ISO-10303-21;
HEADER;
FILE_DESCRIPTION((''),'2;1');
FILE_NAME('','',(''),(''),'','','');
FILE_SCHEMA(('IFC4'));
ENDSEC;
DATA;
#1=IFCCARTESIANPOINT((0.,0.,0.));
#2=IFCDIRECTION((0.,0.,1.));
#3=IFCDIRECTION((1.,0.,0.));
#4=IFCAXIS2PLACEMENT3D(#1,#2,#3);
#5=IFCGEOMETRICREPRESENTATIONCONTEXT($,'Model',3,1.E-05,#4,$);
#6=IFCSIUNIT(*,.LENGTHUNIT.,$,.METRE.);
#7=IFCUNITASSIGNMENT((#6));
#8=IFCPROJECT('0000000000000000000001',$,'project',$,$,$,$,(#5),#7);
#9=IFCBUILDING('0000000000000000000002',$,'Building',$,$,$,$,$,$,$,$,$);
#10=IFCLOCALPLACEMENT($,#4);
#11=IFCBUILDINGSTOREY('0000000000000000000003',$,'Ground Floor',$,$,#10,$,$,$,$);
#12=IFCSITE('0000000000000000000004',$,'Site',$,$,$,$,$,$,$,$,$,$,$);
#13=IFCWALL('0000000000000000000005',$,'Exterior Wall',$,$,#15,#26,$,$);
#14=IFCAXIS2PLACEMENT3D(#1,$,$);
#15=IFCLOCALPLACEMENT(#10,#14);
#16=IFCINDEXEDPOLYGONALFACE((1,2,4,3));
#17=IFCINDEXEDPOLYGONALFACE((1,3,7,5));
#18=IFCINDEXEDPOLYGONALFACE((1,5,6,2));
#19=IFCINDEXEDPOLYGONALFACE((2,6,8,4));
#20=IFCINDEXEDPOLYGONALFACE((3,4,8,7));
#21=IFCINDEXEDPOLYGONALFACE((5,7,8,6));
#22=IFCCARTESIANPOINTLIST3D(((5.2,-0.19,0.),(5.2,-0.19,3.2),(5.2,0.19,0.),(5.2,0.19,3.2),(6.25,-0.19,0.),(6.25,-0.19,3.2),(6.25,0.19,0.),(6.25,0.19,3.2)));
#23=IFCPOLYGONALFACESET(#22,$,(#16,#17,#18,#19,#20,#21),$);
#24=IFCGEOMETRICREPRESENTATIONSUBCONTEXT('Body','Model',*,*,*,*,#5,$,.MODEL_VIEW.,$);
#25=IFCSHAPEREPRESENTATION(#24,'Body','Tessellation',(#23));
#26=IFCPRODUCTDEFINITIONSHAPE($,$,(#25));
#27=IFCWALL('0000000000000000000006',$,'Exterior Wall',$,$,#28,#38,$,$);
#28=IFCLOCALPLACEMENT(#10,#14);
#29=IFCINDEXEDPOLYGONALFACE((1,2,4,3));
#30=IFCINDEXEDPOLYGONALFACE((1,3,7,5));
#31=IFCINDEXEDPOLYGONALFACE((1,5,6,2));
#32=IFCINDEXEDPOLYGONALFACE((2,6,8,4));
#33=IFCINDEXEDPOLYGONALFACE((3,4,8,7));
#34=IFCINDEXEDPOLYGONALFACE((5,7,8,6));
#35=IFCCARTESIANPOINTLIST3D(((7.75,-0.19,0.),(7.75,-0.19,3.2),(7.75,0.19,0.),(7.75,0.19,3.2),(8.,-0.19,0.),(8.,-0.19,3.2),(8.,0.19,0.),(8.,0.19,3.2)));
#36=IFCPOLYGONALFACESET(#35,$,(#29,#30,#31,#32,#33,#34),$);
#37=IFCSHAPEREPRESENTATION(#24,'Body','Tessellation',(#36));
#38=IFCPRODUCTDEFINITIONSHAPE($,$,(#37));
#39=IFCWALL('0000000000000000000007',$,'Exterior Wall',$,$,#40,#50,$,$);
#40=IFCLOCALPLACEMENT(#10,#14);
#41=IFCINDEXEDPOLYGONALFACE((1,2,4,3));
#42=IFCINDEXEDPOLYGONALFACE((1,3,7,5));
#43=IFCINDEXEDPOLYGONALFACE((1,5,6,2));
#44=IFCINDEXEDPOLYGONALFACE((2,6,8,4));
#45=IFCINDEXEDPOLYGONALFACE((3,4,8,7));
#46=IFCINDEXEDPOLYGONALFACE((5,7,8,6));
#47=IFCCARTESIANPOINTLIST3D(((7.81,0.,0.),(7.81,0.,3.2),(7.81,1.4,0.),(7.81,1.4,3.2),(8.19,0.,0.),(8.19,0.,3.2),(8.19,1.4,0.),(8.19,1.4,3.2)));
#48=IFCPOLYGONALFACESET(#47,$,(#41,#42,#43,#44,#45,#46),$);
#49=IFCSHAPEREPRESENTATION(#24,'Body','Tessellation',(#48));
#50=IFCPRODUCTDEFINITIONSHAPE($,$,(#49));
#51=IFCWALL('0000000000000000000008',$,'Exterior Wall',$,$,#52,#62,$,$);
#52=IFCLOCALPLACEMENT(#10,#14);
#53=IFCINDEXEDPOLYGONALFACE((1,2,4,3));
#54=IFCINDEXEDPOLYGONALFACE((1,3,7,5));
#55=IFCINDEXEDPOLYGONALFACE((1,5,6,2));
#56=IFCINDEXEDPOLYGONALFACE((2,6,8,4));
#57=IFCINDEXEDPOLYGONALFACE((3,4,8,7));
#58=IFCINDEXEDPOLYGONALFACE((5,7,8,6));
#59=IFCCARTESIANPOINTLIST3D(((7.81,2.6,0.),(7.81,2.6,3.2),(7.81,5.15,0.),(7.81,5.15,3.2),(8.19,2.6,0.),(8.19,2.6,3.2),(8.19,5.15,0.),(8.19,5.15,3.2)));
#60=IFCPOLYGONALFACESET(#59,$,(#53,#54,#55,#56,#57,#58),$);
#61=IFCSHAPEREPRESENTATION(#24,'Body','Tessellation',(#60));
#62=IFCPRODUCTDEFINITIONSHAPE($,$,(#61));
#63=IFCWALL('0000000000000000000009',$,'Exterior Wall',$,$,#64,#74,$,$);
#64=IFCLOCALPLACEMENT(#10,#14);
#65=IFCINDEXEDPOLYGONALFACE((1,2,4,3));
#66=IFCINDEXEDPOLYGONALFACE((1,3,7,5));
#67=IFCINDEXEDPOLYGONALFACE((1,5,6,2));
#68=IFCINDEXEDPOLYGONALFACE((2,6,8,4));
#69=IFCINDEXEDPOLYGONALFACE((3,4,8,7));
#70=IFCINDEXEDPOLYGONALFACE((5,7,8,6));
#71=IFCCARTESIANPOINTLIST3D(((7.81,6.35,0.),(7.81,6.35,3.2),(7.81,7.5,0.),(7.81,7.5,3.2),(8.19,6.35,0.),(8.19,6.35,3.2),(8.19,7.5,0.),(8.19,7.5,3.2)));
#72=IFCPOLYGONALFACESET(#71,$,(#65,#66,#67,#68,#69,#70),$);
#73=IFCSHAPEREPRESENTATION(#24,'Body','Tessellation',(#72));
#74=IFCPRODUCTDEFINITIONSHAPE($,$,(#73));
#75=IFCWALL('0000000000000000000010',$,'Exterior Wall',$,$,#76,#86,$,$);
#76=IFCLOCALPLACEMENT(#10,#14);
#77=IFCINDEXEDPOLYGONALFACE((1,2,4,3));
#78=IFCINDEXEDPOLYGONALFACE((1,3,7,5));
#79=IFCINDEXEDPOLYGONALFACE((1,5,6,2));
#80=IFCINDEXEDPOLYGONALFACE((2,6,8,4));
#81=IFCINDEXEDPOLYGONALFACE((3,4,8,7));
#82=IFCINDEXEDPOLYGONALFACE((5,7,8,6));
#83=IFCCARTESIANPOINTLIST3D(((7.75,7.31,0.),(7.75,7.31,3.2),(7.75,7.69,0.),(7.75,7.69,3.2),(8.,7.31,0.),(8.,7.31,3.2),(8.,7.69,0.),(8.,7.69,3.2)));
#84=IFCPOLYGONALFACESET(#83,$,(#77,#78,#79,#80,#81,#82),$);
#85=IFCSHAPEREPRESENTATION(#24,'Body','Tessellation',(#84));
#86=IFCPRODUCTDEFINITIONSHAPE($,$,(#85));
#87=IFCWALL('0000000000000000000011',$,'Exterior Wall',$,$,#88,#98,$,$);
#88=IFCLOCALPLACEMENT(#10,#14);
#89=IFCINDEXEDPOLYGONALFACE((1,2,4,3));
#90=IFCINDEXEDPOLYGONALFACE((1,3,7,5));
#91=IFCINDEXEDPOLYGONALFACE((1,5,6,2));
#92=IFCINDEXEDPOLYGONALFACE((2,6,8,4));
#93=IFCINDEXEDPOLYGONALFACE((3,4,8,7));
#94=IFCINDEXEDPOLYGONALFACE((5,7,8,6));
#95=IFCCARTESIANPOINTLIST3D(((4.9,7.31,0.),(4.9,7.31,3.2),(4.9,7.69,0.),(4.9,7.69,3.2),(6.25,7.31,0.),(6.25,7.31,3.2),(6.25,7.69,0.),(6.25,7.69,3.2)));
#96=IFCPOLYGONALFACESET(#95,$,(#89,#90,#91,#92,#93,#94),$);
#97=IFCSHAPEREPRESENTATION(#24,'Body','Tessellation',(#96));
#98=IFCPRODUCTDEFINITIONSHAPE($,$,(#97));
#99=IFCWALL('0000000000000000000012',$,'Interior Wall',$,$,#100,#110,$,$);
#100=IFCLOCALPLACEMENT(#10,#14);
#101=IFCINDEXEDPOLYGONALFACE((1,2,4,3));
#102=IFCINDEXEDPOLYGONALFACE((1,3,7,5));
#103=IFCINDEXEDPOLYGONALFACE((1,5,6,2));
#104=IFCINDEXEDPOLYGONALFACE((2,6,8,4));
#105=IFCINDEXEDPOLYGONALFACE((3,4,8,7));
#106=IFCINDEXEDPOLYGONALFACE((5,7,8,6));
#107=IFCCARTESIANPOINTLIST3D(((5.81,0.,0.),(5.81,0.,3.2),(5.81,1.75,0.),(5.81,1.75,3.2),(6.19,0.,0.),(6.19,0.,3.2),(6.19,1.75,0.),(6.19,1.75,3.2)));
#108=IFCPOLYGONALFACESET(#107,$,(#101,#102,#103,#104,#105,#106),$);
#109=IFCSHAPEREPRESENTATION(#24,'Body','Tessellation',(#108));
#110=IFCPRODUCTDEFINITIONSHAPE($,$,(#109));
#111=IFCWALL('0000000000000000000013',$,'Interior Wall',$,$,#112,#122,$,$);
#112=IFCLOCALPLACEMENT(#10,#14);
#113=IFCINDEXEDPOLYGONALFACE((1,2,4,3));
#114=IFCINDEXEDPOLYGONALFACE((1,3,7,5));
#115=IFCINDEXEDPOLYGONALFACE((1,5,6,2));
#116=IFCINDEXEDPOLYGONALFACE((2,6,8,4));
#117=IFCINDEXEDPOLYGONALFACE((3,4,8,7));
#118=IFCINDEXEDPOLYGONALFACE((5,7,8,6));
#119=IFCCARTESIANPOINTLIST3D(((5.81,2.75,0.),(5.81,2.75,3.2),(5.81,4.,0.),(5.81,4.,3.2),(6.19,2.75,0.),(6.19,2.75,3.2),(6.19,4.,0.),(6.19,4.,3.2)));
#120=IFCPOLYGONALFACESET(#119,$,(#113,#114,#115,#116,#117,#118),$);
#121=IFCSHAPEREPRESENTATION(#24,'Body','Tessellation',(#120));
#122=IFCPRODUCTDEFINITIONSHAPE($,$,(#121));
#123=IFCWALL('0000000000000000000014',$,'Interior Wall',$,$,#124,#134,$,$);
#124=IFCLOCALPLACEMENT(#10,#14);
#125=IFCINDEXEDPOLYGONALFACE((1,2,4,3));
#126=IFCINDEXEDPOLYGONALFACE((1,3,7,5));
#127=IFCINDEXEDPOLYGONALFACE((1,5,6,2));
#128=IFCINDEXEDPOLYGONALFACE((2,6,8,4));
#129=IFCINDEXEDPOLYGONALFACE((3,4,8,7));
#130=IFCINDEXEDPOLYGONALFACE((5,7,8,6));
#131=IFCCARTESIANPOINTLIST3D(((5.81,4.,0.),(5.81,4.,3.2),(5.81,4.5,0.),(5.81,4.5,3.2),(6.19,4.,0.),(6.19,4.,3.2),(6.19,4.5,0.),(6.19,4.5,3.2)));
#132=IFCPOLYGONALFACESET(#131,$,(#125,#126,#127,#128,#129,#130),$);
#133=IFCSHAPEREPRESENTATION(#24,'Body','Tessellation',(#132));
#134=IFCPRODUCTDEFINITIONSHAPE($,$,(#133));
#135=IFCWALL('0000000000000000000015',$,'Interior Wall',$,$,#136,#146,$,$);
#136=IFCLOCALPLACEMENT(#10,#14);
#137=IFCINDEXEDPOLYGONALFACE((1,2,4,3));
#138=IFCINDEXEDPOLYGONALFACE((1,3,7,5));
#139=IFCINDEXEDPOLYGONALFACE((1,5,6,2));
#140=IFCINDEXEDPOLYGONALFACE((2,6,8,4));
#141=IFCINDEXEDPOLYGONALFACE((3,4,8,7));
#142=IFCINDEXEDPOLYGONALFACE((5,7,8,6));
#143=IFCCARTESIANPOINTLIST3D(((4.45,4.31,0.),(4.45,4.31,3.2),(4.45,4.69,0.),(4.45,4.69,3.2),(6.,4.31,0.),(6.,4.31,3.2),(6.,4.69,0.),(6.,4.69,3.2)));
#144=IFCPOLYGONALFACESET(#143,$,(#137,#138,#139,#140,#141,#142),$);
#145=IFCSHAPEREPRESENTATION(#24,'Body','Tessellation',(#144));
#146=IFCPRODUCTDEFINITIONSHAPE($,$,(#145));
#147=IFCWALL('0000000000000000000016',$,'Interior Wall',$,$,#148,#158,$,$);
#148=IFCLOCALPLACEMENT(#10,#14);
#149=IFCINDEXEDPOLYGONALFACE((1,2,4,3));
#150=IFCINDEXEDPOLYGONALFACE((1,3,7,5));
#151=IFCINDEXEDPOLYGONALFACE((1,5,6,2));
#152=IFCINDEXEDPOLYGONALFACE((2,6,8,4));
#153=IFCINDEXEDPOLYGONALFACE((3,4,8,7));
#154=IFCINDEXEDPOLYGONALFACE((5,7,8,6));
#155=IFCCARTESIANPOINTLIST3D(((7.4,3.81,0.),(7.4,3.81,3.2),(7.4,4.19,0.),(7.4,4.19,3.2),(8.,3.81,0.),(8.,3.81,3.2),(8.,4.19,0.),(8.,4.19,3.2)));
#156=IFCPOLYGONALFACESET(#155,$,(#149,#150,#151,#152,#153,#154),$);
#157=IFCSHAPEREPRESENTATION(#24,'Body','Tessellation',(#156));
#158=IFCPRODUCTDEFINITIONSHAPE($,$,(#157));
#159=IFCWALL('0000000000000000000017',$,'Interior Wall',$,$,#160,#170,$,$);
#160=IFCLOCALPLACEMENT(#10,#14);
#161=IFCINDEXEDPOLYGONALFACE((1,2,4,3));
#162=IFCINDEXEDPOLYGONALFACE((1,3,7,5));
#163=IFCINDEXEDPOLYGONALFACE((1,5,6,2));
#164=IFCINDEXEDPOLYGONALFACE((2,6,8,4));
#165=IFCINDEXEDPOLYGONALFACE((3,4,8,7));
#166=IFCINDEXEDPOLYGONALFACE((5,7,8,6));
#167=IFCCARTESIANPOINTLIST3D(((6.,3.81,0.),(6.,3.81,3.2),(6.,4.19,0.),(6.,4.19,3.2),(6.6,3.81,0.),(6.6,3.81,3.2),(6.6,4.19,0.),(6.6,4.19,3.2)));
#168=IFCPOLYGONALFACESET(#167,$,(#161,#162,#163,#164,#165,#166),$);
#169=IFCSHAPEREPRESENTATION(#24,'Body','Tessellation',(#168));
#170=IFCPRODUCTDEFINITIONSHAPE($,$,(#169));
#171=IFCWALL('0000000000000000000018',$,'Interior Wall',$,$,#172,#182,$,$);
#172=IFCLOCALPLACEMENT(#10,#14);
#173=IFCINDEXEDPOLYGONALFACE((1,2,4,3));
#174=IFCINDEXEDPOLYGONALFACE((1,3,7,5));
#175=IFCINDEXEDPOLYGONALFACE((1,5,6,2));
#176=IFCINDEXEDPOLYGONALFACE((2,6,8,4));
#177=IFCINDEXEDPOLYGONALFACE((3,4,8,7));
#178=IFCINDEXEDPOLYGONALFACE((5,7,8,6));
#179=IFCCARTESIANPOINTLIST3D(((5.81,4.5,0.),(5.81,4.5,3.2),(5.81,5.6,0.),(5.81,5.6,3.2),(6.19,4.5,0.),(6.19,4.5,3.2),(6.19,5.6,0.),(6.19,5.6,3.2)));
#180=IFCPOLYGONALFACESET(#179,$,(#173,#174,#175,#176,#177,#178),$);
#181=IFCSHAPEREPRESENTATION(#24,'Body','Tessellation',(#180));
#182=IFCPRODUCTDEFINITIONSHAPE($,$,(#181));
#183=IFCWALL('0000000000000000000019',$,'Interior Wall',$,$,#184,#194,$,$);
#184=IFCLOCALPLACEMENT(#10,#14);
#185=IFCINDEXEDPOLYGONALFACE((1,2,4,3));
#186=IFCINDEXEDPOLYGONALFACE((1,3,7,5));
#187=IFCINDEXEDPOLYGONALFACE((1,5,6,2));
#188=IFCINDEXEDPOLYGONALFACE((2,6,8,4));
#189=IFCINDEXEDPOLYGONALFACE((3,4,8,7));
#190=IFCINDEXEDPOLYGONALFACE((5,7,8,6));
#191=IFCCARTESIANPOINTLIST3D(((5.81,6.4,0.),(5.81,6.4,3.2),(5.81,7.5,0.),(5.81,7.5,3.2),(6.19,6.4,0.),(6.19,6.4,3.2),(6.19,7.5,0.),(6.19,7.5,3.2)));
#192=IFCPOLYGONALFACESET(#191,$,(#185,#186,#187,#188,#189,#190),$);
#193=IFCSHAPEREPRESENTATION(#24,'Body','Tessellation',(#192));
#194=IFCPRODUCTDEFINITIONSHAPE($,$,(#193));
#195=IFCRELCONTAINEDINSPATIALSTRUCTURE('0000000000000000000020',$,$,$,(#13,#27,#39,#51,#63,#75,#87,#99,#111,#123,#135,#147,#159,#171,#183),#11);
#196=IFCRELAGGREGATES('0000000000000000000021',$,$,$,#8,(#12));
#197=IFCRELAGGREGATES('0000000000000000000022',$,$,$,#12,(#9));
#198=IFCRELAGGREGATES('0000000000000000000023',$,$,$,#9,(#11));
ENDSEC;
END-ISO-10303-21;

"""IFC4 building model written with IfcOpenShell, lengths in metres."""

from ifc_helpers import new_model, si_unit, frame, origin_with_axes, place, context, subcontext, project, spatial, indexed_curve, outline, extrude, element, save


model = new_model("IFC4")

# Units and contexts
model_context = context("Model", 3, precision=1e-05, world=origin_with_axes())
body_context = subcontext(model_context, "Body", "Model", "MODEL_VIEW")
ifc_project = project(units=[si_unit("LENGTHUNIT", "METRE")], contexts=[model_context])

# Site, building, storey
site = spatial("IfcSite", under=ifc_project, Name="Site")
building = spatial("IfcBuilding", under=site, Name="Building")
storey_placement = place(None, origin_with_axes())
storey = spatial("IfcBuildingStorey", under=building, at=storey_placement, Name="Ground Floor")

# Walls
wall_1_placement = place(storey_placement, frame((5.2, 0.0, 0.0), z_axis=(0.0, 0.0, 1.0), x_axis=(1.0, 0.0, 0.0)))
element("IfcWall", 1, at=wall_1_placement, inside=storey, Name="Exterior Wall", context=body_context, shape_type="SweptSolid", body=[
    extrude(outline(indexed_curve([(0.0, 0.0), (0.0, 0.38), (1.05, 0.38), (1.05, 0.0), (0.0, 0.0)], self_intersect=False)), frame((0.0, -0.19, 0.0), z_axis=(0.0, 0.0, 1.0), x_axis=(1.0, 0.0, 0.0)), (0.0, 0.0, 1.0), 3.2),
])
wall_2_placement = place(storey_placement, frame((7.75, 0.0, 0.0), z_axis=(0.0, 0.0, 1.0), x_axis=(1.0, 0.0, 0.0)))
element("IfcWall", 2, at=wall_2_placement, inside=storey, Name="Exterior Wall", context=body_context, shape_type="SweptSolid", body=[
    extrude(outline(indexed_curve([(0.0, 0.0), (0.0, 0.38), (0.25, 0.38), (0.25, 0.0), (0.0, 0.0)], self_intersect=False)), frame((0.0, -0.19, 0.0), z_axis=(0.0, 0.0, 1.0), x_axis=(1.0, 0.0, 0.0)), (0.0, 0.0, 1.0), 3.2),
])
wall_3_placement = place(storey_placement, frame((8.0, 0.0, 0.0), z_axis=(0.0, 0.0, 1.0), x_axis=(0.0, 1.0, 0.0)))
element("IfcWall", 3, at=wall_3_placement, inside=storey, Name="Exterior Wall", context=body_context, shape_type="SweptSolid", body=[
    extrude(outline(indexed_curve([(0.0, 0.0), (0.0, 0.38), (1.4, 0.38), (1.4, 0.0), (0.0, 0.0)], self_intersect=False)), frame((0.0, -0.19, 0.0), z_axis=(0.0, 0.0, 1.0), x_axis=(1.0, 0.0, 0.0)), (0.0, 0.0, 1.0), 3.2),
])
wall_4_placement = place(storey_placement, frame((8.0, 2.6, 0.0), z_axis=(0.0, 0.0, 1.0), x_axis=(0.0, 1.0, 0.0)))
element("IfcWall", 4, at=wall_4_placement, inside=storey, Name="Exterior Wall", context=body_context, shape_type="SweptSolid", body=[
    extrude(outline(indexed_curve([(0.0, 0.0), (0.0, 0.38), (2.55, 0.38), (2.55, 0.0), (0.0, 0.0)], self_intersect=False)), frame((0.0, -0.19, 0.0), z_axis=(0.0, 0.0, 1.0), x_axis=(1.0, 0.0, 0.0)), (0.0, 0.0, 1.0), 3.2),
])
wall_5_placement = place(storey_placement, frame((8.0, 6.35, 0.0), z_axis=(0.0, 0.0, 1.0), x_axis=(0.0, 1.0, 0.0)))
element("IfcWall", 5, at=wall_5_placement, inside=storey, Name="Exterior Wall", context=body_context, shape_type="SweptSolid", body=[
    extrude(outline(indexed_curve([(0.0, 0.0), (0.0, 0.38), (1.15, 0.38), (1.15, 0.0), (0.0, 0.0)], self_intersect=False)), frame((0.0, -0.19, 0.0), z_axis=(0.0, 0.0, 1.0), x_axis=(1.0, 0.0, 0.0)), (0.0, 0.0, 1.0), 3.2),
])
wall_6_placement = place(storey_placement, frame((8.0, 7.5, 0.0), z_axis=(0.0, 0.0, 1.0), x_axis=(-1.0, 0.0, 0.0)))
element("IfcWall", 6, at=wall_6_placement, inside=storey, Name="Exterior Wall", context=body_context, shape_type="SweptSolid", body=[
    extrude(outline(indexed_curve([(0.0, 0.0), (0.0, 0.38), (0.25, 0.38), (0.25, 0.0), (0.0, 0.0)], self_intersect=False)), frame((0.0, -0.19, 0.0), z_axis=(0.0, 0.0, 1.0), x_axis=(1.0, 0.0, 0.0)), (0.0, 0.0, 1.0), 3.2),
])
wall_7_placement = place(storey_placement, frame((6.25, 7.5, 0.0), z_axis=(0.0, 0.0, 1.0), x_axis=(-1.0, 0.0, 0.0)))
element("IfcWall", 7, at=wall_7_placement, inside=storey, Name="Exterior Wall", context=body_context, shape_type="SweptSolid", body=[
    extrude(outline(indexed_curve([(0.0, 0.0), (0.0, 0.38), (1.35, 0.38), (1.35, 0.0), (0.0, 0.0)], self_intersect=False)), frame((0.0, -0.19, 0.0), z_axis=(0.0, 0.0, 1.0), x_axis=(1.0, 0.0, 0.0)), (0.0, 0.0, 1.0), 3.2),
])
wall_8_placement = place(storey_placement, frame((6.0, 0.0, 0.0), z_axis=(0.0, 0.0, 1.0), x_axis=(0.0, 1.0, 0.0)))
element("IfcWall", 8, at=wall_8_placement, inside=storey, Name="Interior Wall", context=body_context, shape_type="SweptSolid", body=[
    extrude(outline(indexed_curve([(0.0, 0.0), (0.0, 0.38), (1.75, 0.38), (1.75, 0.0), (0.0, 0.0)], self_intersect=False)), frame((0.0, -0.19, 0.0), z_axis=(0.0, 0.0, 1.0), x_axis=(1.0, 0.0, 0.0)), (0.0, 0.0, 1.0), 3.2),
])
wall_9_placement = place(storey_placement, frame((6.0, 2.75, 0.0), z_axis=(0.0, 0.0, 1.0), x_axis=(0.0, 1.0, 0.0)))
element("IfcWall", 9, at=wall_9_placement, inside=storey, Name="Interior Wall", context=body_context, shape_type="SweptSolid", body=[
    extrude(outline(indexed_curve([(0.0, 0.0), (0.0, 0.38), (1.25, 0.38), (1.25, 0.0), (0.0, 0.0)], self_intersect=False)), frame((0.0, -0.19, 0.0), z_axis=(0.0, 0.0, 1.0), x_axis=(1.0, 0.0, 0.0)), (0.0, 0.0, 1.0), 3.2),
])
wall_10_placement = place(storey_placement, frame((6.0, 4.0, 0.0), z_axis=(0.0, 0.0, 1.0), x_axis=(0.0, 1.0, 0.0)))
element("IfcWall", 10, at=wall_10_placement, inside=storey, Name="Interior Wall", context=body_context, shape_type="SweptSolid", body=[
    extrude(outline(indexed_curve([(0.0, 0.0), (0.0, 0.38), (0.5, 0.38), (0.5, 0.0), (0.0, 0.0)], self_intersect=False)), frame((0.0, -0.19, 0.0), z_axis=(0.0, 0.0, 1.0), x_axis=(1.0, 0.0, 0.0)), (0.0, 0.0, 1.0), 3.2),
])
wall_11_placement = place(storey_placement, frame((6.0, 4.5, 0.0), z_axis=(0.0, 0.0, 1.0), x_axis=(-1.0, 0.0, 0.0)))
element("IfcWall", 11, at=wall_11_placement, inside=storey, Name="Interior Wall", context=body_context, shape_type="SweptSolid", body=[
    extrude(outline(indexed_curve([(0.0, 0.0), (0.0, 0.38), (1.55, 0.38), (1.55, 0.0), (0.0, 0.0)], self_intersect=False)), frame((0.0, -0.19, 0.0), z_axis=(0.0, 0.0, 1.0), x_axis=(1.0, 0.0, 0.0)), (0.0, 0.0, 1.0), 3.2),
])
for number, where, z_axis, x_axis, name in (
    (12, (8.0, 4.0, 0.0), (0.0, 0.0, 1.0), (-1.0, 0.0, 0.0), "Interior Wall"),
    (13, (6.6, 4.0, 0.0), (0.0, 0.0, 1.0), (-1.0, 0.0, 0.0), "Interior Wall"),
):
    element("IfcWall", number, at=place(storey_placement, frame(where, z_axis=z_axis, x_axis=x_axis)), inside=storey, Name=name, context=body_context, shape_type="SweptSolid", body=[
        extrude(outline(indexed_curve([(0.0, 0.0), (0.0, 0.38), (0.6, 0.38), (0.6, 0.0), (0.0, 0.0)], self_intersect=False)), frame((0.0, -0.19, 0.0), z_axis=(0.0, 0.0, 1.0), x_axis=(1.0, 0.0, 0.0)), (0.0, 0.0, 1.0), 3.2),
    ])
for number, where, z_axis, x_axis, name in (
    (14, (6.0, 4.5, 0.0), (0.0, 0.0, 1.0), (0.0, 1.0, 0.0), "Interior Wall"),
    (15, (6.0, 6.4, 0.0), (0.0, 0.0, 1.0), (0.0, 1.0, 0.0), "Interior Wall"),
):
    element("IfcWall", number, at=place(storey_placement, frame(where, z_axis=z_axis, x_axis=x_axis)), inside=storey, Name=name, context=body_context, shape_type="SweptSolid", body=[
        extrude(outline(indexed_curve([(0.0, 0.0), (0.0, 0.38), (1.1, 0.38), (1.1, 0.0), (0.0, 0.0)], self_intersect=False)), frame((0.0, -0.19, 0.0), z_axis=(0.0, 0.0, 1.0), x_axis=(1.0, 0.0, 0.0)), (0.0, 0.0, 1.0), 3.2),
    ])

save(model, "model.ifc")
